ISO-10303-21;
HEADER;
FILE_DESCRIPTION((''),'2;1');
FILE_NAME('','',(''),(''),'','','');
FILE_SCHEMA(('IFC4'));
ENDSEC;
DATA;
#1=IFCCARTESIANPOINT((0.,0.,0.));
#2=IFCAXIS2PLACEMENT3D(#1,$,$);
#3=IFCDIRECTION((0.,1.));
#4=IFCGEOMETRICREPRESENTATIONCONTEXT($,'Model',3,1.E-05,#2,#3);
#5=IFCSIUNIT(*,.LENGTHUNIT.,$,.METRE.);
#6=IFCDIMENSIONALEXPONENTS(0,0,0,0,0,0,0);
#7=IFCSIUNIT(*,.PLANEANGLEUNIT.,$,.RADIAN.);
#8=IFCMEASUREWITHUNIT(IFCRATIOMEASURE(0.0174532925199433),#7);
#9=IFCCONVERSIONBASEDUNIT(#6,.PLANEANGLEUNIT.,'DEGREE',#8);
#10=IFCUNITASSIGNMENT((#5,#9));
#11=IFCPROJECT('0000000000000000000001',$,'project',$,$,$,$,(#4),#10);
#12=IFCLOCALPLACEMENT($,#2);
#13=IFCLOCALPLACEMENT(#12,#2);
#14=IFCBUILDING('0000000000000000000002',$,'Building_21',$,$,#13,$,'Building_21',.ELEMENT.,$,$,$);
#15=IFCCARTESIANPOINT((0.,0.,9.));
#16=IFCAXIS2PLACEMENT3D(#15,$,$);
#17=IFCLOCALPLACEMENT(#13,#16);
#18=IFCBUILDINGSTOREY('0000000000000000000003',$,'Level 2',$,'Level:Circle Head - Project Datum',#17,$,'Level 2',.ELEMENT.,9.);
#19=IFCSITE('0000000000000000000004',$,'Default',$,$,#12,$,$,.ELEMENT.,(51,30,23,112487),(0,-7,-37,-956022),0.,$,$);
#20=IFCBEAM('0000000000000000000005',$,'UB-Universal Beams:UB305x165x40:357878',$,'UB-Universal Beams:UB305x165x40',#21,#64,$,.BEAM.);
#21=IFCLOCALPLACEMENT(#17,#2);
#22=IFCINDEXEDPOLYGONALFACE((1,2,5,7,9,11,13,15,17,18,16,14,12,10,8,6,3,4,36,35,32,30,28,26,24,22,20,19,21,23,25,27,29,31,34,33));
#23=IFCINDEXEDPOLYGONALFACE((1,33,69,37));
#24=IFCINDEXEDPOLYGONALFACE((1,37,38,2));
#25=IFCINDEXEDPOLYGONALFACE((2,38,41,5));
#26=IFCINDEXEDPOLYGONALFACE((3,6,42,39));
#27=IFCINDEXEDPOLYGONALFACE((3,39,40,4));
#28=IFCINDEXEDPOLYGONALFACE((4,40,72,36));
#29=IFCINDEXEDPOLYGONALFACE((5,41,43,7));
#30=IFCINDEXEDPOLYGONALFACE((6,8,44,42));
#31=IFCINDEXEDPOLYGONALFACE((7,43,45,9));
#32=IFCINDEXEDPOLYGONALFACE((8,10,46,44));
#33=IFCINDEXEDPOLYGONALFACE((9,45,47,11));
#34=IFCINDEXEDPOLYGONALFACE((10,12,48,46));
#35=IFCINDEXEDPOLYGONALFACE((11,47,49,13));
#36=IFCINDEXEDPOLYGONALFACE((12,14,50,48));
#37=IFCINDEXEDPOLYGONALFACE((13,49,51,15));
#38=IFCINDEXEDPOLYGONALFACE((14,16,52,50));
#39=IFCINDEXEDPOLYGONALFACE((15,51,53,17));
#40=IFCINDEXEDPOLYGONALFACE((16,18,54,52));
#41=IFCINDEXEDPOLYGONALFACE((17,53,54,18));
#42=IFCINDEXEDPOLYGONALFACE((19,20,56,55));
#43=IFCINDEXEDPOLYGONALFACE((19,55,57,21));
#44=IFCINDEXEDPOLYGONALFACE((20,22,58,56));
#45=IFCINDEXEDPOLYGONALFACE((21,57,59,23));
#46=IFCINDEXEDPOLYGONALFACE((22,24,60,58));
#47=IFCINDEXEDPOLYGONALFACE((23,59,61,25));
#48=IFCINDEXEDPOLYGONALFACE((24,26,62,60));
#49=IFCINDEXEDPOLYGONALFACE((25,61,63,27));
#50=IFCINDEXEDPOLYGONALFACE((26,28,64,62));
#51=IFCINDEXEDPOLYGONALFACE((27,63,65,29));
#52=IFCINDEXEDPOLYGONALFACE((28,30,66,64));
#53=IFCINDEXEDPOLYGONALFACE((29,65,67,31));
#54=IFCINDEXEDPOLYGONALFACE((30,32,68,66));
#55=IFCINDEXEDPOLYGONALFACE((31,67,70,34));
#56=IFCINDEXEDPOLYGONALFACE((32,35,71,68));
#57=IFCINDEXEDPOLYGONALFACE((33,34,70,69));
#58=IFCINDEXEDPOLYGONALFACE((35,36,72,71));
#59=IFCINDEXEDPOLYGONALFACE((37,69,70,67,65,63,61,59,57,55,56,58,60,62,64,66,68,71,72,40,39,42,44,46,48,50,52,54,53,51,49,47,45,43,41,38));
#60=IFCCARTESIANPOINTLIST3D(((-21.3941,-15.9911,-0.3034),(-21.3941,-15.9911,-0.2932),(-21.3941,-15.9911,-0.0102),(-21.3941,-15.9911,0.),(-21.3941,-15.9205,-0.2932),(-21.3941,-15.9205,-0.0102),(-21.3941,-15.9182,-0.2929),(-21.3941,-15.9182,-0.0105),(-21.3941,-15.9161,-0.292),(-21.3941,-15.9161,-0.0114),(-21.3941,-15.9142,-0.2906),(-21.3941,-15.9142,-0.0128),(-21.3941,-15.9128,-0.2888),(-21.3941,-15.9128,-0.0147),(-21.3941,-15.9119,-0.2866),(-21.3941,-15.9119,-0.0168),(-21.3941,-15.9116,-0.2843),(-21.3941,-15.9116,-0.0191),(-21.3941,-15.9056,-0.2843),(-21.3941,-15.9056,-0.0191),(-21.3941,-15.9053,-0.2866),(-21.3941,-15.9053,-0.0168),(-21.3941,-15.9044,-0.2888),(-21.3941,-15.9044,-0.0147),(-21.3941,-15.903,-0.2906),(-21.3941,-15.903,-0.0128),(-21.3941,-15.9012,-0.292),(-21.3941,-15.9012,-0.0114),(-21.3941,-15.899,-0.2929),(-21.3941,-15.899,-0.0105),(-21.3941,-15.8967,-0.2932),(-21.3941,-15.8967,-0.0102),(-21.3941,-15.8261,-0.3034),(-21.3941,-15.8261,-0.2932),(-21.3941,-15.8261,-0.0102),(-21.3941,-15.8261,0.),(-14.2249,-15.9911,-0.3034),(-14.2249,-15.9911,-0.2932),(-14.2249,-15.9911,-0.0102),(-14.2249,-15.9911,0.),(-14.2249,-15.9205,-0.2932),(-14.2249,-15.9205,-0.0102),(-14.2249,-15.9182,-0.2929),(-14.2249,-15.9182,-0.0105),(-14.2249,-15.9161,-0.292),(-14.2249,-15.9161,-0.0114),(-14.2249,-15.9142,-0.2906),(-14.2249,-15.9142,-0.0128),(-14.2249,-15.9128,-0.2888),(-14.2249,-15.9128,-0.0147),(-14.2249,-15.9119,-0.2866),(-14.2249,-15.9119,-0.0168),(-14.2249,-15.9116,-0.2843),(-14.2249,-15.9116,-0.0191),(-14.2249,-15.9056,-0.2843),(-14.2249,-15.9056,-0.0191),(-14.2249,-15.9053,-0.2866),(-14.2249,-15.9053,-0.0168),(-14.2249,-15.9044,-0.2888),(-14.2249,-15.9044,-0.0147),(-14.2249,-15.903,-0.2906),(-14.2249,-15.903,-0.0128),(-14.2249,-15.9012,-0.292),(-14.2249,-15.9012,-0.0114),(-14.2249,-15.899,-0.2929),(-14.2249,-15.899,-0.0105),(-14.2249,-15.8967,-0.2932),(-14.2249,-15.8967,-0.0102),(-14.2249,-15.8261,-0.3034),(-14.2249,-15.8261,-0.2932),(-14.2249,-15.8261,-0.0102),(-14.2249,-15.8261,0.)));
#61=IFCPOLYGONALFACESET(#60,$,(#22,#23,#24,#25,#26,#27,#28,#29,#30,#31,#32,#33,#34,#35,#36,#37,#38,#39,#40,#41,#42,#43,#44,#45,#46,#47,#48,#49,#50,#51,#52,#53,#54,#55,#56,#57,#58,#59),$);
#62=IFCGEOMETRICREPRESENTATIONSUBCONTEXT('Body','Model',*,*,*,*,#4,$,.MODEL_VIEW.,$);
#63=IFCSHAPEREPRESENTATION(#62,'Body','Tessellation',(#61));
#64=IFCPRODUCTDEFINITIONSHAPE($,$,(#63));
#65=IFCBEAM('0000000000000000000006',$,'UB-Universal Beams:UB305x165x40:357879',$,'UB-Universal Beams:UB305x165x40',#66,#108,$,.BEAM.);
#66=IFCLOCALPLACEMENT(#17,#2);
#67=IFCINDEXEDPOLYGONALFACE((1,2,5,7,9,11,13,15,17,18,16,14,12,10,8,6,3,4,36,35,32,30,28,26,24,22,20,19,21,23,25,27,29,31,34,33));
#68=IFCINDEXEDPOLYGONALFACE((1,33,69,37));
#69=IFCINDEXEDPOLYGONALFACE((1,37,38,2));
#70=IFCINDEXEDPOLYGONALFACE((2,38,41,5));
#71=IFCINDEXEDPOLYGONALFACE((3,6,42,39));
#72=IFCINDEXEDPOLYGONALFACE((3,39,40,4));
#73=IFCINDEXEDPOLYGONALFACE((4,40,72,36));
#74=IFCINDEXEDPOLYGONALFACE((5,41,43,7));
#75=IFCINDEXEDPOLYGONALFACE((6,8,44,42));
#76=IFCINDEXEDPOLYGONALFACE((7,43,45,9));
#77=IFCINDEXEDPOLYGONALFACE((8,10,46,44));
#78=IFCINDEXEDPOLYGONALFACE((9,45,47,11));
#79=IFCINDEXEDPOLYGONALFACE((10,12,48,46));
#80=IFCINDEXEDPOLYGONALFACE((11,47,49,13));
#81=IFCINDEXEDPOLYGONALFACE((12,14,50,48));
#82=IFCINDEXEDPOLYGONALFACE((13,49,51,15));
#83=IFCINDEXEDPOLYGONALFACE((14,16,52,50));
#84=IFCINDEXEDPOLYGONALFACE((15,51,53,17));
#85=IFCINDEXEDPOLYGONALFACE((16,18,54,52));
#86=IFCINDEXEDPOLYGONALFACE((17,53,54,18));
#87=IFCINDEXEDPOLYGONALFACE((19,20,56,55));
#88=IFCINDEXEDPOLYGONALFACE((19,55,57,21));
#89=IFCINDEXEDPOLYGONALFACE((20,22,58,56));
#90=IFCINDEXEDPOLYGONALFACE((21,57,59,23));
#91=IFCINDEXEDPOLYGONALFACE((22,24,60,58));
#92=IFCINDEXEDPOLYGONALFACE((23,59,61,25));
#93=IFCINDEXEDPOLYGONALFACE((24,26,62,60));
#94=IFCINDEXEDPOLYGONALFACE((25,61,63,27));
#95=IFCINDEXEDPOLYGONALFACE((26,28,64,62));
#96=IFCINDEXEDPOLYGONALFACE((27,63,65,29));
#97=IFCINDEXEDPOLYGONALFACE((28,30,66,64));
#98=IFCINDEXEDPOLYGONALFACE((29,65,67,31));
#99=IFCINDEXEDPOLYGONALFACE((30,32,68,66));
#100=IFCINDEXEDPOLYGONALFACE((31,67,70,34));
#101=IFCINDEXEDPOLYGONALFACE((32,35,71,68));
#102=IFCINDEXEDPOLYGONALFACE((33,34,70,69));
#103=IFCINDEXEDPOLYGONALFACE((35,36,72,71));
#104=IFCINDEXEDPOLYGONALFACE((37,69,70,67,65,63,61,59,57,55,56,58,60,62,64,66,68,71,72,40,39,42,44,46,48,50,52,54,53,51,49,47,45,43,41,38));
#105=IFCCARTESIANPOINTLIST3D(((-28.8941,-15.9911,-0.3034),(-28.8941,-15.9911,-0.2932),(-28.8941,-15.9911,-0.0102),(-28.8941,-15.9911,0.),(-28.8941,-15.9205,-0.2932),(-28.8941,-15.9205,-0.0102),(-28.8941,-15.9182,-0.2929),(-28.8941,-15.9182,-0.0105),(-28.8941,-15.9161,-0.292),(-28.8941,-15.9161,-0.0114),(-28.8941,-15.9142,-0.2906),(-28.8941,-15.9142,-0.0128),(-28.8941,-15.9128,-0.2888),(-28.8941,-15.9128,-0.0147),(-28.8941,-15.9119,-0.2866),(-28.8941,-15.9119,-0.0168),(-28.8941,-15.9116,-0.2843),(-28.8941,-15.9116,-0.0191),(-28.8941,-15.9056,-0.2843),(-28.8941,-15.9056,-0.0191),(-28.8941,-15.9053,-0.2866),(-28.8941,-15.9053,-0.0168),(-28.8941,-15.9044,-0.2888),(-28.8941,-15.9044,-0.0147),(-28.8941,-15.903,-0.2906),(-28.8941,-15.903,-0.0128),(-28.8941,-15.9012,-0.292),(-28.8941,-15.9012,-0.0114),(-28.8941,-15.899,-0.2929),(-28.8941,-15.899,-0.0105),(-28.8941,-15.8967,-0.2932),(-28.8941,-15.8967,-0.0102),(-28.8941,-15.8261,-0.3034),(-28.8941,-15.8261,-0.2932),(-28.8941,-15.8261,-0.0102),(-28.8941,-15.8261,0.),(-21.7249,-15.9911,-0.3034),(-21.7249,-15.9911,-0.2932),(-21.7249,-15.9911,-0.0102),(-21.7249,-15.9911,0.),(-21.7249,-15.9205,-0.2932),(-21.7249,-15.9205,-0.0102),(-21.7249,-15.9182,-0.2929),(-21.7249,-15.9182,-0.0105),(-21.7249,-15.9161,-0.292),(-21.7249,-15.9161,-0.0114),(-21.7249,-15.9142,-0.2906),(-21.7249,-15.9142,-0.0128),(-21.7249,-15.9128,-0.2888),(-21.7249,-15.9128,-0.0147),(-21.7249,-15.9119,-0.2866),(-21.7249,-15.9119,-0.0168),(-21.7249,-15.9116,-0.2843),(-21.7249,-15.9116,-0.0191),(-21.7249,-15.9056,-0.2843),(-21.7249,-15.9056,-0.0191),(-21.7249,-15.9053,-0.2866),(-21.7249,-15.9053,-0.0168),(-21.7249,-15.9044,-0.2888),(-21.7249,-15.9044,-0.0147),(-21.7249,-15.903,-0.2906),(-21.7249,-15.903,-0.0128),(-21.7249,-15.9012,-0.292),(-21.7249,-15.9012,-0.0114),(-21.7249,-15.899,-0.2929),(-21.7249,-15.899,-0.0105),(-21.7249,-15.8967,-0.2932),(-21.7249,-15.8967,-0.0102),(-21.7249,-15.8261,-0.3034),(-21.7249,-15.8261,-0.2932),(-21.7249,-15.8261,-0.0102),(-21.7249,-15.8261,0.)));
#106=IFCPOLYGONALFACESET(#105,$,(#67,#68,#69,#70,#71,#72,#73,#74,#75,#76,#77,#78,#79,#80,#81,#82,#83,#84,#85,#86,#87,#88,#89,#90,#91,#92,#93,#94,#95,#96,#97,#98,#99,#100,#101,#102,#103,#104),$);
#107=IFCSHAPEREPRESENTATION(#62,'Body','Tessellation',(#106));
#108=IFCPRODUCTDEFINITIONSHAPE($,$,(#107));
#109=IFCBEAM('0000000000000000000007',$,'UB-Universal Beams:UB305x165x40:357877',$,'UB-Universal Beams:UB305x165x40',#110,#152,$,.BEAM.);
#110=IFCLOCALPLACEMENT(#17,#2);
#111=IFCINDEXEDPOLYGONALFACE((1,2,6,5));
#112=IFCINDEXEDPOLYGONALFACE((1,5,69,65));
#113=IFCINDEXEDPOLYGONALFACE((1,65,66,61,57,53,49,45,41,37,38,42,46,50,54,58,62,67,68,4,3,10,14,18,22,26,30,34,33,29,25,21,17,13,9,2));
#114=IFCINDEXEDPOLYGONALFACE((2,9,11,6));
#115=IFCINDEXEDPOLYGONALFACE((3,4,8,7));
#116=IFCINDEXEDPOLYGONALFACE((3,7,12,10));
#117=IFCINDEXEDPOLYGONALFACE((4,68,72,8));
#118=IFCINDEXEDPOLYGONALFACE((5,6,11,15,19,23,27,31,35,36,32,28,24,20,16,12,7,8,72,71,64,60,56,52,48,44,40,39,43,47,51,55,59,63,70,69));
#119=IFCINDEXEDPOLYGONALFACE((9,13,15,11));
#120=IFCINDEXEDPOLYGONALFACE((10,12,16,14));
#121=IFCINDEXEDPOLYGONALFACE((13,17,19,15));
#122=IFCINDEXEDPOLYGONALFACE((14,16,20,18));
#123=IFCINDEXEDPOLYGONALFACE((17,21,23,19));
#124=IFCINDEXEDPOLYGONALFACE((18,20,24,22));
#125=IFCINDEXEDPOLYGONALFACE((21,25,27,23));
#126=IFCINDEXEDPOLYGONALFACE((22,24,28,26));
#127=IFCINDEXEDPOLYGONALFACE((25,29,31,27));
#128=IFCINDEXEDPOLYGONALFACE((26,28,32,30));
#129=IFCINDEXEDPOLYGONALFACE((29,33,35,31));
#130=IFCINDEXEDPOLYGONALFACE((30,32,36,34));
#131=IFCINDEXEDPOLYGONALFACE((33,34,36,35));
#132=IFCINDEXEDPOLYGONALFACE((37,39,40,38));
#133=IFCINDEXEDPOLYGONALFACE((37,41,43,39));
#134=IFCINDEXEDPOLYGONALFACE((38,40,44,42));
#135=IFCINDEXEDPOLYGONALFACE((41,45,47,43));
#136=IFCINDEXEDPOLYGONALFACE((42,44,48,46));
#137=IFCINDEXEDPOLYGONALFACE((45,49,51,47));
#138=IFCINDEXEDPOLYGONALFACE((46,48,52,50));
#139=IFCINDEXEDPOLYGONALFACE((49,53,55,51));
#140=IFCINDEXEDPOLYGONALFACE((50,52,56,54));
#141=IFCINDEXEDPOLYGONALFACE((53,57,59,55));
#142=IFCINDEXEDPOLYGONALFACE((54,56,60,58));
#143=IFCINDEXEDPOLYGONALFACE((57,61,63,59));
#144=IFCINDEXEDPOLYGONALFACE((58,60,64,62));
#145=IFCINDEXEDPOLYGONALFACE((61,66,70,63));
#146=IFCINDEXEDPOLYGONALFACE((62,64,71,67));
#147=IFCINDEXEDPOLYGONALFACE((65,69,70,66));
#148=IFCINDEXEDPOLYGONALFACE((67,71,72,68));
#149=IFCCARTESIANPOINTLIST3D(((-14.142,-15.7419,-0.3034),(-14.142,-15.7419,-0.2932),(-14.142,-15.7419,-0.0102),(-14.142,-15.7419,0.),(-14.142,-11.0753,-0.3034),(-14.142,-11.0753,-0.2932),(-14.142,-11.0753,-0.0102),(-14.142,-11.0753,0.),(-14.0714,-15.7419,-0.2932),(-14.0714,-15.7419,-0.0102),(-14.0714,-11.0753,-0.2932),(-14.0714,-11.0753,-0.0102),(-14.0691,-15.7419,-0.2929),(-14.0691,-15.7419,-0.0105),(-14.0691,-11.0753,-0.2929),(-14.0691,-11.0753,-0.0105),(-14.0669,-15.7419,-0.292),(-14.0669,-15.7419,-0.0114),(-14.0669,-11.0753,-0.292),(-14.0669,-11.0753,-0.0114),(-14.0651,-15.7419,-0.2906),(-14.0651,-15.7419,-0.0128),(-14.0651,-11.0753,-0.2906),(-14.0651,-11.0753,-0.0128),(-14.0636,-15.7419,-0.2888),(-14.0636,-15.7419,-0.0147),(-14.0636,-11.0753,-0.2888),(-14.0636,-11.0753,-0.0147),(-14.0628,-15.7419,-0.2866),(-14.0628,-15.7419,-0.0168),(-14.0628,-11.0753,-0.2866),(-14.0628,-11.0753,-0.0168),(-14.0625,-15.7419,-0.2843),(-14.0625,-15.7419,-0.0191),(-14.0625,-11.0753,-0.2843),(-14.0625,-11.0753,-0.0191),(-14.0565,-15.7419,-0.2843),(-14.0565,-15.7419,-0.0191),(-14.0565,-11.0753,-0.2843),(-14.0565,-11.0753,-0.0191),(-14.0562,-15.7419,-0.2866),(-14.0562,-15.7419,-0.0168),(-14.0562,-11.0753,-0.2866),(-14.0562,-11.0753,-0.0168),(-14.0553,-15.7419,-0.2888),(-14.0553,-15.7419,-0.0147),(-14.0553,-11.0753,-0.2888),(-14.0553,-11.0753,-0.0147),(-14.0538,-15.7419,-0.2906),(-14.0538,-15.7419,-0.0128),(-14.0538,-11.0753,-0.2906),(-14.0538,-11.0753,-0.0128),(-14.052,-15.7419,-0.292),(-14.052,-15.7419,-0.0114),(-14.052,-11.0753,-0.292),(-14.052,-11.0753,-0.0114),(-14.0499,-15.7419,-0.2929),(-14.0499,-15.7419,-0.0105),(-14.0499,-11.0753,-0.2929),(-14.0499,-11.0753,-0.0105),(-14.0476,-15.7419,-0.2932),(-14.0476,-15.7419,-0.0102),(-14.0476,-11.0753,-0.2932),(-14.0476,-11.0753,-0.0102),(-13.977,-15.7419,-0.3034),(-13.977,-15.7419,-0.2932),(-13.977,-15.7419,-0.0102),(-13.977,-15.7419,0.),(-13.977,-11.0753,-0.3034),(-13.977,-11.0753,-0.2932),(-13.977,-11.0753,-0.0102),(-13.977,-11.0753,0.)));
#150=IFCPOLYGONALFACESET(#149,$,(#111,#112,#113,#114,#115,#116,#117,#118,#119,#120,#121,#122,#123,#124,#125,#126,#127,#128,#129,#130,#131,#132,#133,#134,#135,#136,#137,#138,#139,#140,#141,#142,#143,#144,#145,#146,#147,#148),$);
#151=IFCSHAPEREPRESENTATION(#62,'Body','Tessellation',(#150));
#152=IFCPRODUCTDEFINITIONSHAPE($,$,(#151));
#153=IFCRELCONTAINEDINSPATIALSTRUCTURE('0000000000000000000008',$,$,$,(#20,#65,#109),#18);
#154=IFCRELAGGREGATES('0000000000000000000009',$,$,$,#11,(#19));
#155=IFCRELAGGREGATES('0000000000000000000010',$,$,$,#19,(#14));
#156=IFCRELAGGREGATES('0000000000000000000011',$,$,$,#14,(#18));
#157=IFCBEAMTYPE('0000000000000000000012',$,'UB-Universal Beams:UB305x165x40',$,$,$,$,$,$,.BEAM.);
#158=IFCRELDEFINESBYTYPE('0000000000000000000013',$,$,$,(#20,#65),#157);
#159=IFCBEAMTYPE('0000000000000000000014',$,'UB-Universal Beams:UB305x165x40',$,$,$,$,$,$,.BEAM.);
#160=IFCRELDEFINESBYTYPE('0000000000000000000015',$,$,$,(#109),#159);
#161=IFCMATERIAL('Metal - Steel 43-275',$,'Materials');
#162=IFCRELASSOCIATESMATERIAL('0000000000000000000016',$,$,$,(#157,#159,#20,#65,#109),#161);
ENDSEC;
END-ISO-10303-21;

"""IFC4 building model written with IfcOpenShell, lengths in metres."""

from ifc_helpers import new_model, entity, si_unit, converted_unit, direction, frame, frame_2d, origin, place, context, subcontext, project, spatial, polyline, circle_curve, parameter, trimmed, segment, composite_curve, i_section, outline, extrude, source, transform, mapped, material, material_profile, profile_set, profile_usage, type_object, type_shapes, element, save


model = new_model("IFC4")

# Units and contexts
model_context = context("Model", 3, precision=1e-05, world=origin(), true_north=direction((0.0, 1.0)))
body_context = subcontext(model_context, "Body", "Model", "MODEL_VIEW")
ifc_project = project(units=[si_unit("LENGTHUNIT", "METRE"), converted_unit("PLANEANGLEUNIT", "DEGREE", entity("IfcRatioMeasure", 0.0174532925199433), si_unit("PLANEANGLEUNIT", "RADIAN"), dimensions=[0, 0, 0, 0, 0, 0, 0])], contexts=[model_context])

# Site, building, storey
site_placement = place(None, origin())
site = spatial("IfcSite", under=ifc_project, at=site_placement, Name="Default", CompositionType="ELEMENT", RefLatitude=(51, 30, 23, 112487), RefLongitude=(0, -7, -37, -956022), RefElevation=0.0)
building_placement = place(site_placement, origin())
building = spatial("IfcBuilding", under=site, at=building_placement, Name="Building_21", LongName="Building_21", CompositionType="ELEMENT")
storey_placement = place(building_placement, frame((0.0, 0.0, 9.0)))
storey = spatial("IfcBuildingStorey", under=building, at=storey_placement, Name="Level 2", ObjectType="Level:Circle Head - Project Datum", LongName="Level 2", CompositionType="ELEMENT", Elevation=9.0)

# Shared definitions
ifc_material_1 = material(Name="Metal - Steel 43-275", Category="Materials")

# Beams
ifc_material_profile_1 = material_profile(ifc_material_1, outline(composite_curve([segment(polyline([(0.0119, -0.1415, 0.0), (0.0825, -0.1415, 0.0)]), True, "CONTINUOUS"), segment(polyline([(0.0825, -0.1415, 0.0), (0.0825, -0.1517, 0.0)]), True, "CONTINUOUS"), segment(polyline([(0.0825, -0.1517, 0.0), (-0.0825, -0.1517, 0.0)]), True, "CONTINUOUS"), segment(polyline([(-0.0825, -0.1517, 0.0), (-0.0825, -0.1415, 0.0)]), True, "CONTINUOUS"), segment(polyline([(-0.0825, -0.1415, 0.0), (-0.0119, -0.1415, 0.0)]), True, "CONTINUOUS"), segment(trimmed(circle_curve(frame((-0.0119, -0.1326, 0.0), z_axis=(0.0, 0.0, 1.0), x_axis=(-1.0, 0.0, 0.0)), 0.0089), [parameter(90.0)], [parameter(180.0)], True, "PARAMETER"), True, "CONTINUOUS"), segment(polyline([(-0.003, -0.1326, 0.0), (-0.003, 0.1326, 0.0)]), True, "CONTINUOUS"), segment(trimmed(circle_curve(frame((-0.0119, 0.1326, 0.0), z_axis=(0.0, 0.0, 1.0), x_axis=(-1.0, 0.0, 0.0)), 0.0089), [parameter(180.0)], [parameter(270.0)], True, "PARAMETER"), True, "CONTINUOUS"), segment(polyline([(-0.0119, 0.1415, 0.0), (-0.0825, 0.1415, 0.0)]), True, "CONTINUOUS"), segment(polyline([(-0.0825, 0.1415, 0.0), (-0.0825, 0.1517, 0.0)]), True, "CONTINUOUS"), segment(polyline([(-0.0825, 0.1517, 0.0), (0.0825, 0.1517, 0.0)]), True, "CONTINUOUS"), segment(polyline([(0.0825, 0.1517, 0.0), (0.0825, 0.1415, 0.0)]), True, "CONTINUOUS"), segment(polyline([(0.0825, 0.1415, 0.0), (0.0119, 0.1415, 0.0)]), True, "CONTINUOUS"), segment(trimmed(circle_curve(frame((0.0119, 0.1326, 0.0), z_axis=(0.0, 0.0, 1.0), x_axis=(-1.0, 0.0, 0.0)), 0.0089), [parameter(270.0)], [parameter(0.0)], True, "PARAMETER"), True, "CONTINUOUS"), segment(polyline([(0.003, 0.1326, 0.0), (0.003, -0.1326, 0.0)]), True, "CONTINUOUS"), segment(trimmed(circle_curve(frame((0.0119, -0.1326, 0.0), z_axis=(0.0, 0.0, 1.0), x_axis=(-1.0, 0.0, 0.0)), 0.0089), [parameter(0.0)], [parameter(90.0)], True, "PARAMETER"), True, "CONTINUOUS")], self_intersect=False), kind="CURVE"), Name="UB305x165x40")
ifc_material_profile_2 = material_profile(ifc_material_1, outline(composite_curve([segment(polyline([(-1.3346, 0.0825, -0.1415), (-1.3346, 0.0825, -0.1517)]), True, "CONTINUOUS"), segment(polyline([(-1.3346, 0.0825, -0.1517), (-1.3346, -0.0825, -0.1517)]), True, "CONTINUOUS"), segment(polyline([(-1.3346, -0.0825, -0.1517), (-1.3346, -0.0825, -0.1415)]), True, "CONTINUOUS"), segment(polyline([(-1.3346, -0.0825, -0.1415), (-1.3346, -0.003, -0.1415)]), True, "CONTINUOUS"), segment(polyline([(-1.3346, -0.003, -0.1415), (-1.3346, -0.003, 0.1415)]), True, "CONTINUOUS"), segment(polyline([(-1.3346, -0.003, 0.1415), (-1.3346, -0.0825, 0.1415)]), True, "CONTINUOUS"), segment(polyline([(-1.3346, -0.0825, 0.1415), (-1.3346, -0.0825, 0.1517)]), True, "CONTINUOUS"), segment(polyline([(-1.3346, -0.0825, 0.1517), (-1.3346, 0.0825, 0.1517)]), True, "CONTINUOUS"), segment(polyline([(-1.3346, 0.0825, 0.1517), (-1.3346, 0.0825, 0.1415)]), True, "CONTINUOUS"), segment(polyline([(-1.3346, 0.0825, 0.1415), (-1.3346, 0.003, 0.1415)]), True, "CONTINUOUS"), segment(polyline([(-1.3346, 0.003, 0.1415), (-1.3346, 0.003, -0.1415)]), True, "CONTINUOUS"), segment(polyline([(-1.3346, 0.003, -0.1415), (-1.3346, 0.0825, -0.1415)]), True, "CONTINUOUS")], self_intersect=False), kind="CURVE"), Name="UB305x165x40")
ifc_profile_set_1 = profile_set([ifc_material_profile_1, ifc_material_profile_2], Name="UB305x165x40")
ifc_profile_usage_1 = profile_usage(ifc_profile_set_1, cardinal=8)
beam_type_1 = type_object("IfcBeamType", Name="UB-Universal Beams:UB305x165x40", PredefinedType="BEAM", material=ifc_profile_set_1)
shared_shape_1 = source(origin(), body_context, "Body", "SweptSolid", [
    extrude(i_section(OverallWidth=0.165, OverallDepth=0.3034, WebThickness=0.006, FlangeThickness=0.0102, FilletRadius=0.0089, at=frame_2d((0.0, 0.0), x_axis=(0.0, 1.0))), frame((-3.5846, 0.0, 0.0), z_axis=(1.0, 0.0, 0.0), x_axis=(0.0, 0.0, -1.0)), (0.0, 0.0, 1.0), 7.1692),
])
type_shapes(beam_type_1, [shared_shape_1])
beam_1_placement = place(storey_placement, frame((-17.8095, -15.9086, -0.1517)))
element("IfcBeam", 1, at=beam_1_placement, inside=storey, type_object=beam_type_1, material=ifc_profile_usage_1, Name="UB-Universal Beams:UB305x165x40:357878", ObjectType="UB-Universal Beams:UB305x165x40", PredefinedType="BEAM", context=body_context, shape_type="MappedRepresentation", body=[
    mapped(shared_shape_1, transform((0.0, 0.0, 0.0), scale=1.0)),
])
ifc_profile_usage_2 = profile_usage(ifc_profile_set_1, cardinal=8)
beam_2_placement = place(storey_placement, frame((-25.3095, -15.9086, -0.1517)))
element("IfcBeam", 2, at=beam_2_placement, inside=storey, type_object=beam_type_1, material=ifc_profile_usage_2, Name="UB-Universal Beams:UB305x165x40:357879", ObjectType="UB-Universal Beams:UB305x165x40", PredefinedType="BEAM", context=body_context, shape_type="MappedRepresentation", body=[
    mapped(shared_shape_1, transform((0.0, 0.0, 0.0), scale=1.0)),
])
ifc_profile_usage_3 = profile_usage(ifc_profile_set_1, cardinal=8)
beam_type_2 = type_object("IfcBeamType", Name="UB-Universal Beams:UB305x165x40", PredefinedType="BEAM", material=ifc_profile_set_1)
shared_shape_2 = source(origin(), body_context, "Body", "SweptSolid", [
    extrude(i_section(OverallWidth=0.165, OverallDepth=0.3034, WebThickness=0.006, FlangeThickness=0.0102, FilletRadius=0.0089, at=frame_2d((0.0, 0.0), x_axis=(0.0, 1.0))), frame((-2.3333, 0.0, 0.0), z_axis=(1.0, 0.0, 0.0), x_axis=(0.0, 0.0, -1.0)), (0.0, 0.0, 1.0), 4.6666),
])
type_shapes(beam_type_2, [shared_shape_2])
beam_3_placement = place(storey_placement, frame((-14.0595, -13.4086, -0.1517), z_axis=(0.0, 0.0, 1.0), x_axis=(0.0, 1.0, 0.0)))
element("IfcBeam", 3, at=beam_3_placement, inside=storey, type_object=beam_type_2, material=ifc_profile_usage_3, Name="UB-Universal Beams:UB305x165x40:357877", ObjectType="UB-Universal Beams:UB305x165x40", PredefinedType="BEAM", context=body_context, shape_type="MappedRepresentation", body=[
    mapped(shared_shape_2, transform((0.0, 0.0, 0.0), scale=1.0)),
])

save(model, "model.ifc")
